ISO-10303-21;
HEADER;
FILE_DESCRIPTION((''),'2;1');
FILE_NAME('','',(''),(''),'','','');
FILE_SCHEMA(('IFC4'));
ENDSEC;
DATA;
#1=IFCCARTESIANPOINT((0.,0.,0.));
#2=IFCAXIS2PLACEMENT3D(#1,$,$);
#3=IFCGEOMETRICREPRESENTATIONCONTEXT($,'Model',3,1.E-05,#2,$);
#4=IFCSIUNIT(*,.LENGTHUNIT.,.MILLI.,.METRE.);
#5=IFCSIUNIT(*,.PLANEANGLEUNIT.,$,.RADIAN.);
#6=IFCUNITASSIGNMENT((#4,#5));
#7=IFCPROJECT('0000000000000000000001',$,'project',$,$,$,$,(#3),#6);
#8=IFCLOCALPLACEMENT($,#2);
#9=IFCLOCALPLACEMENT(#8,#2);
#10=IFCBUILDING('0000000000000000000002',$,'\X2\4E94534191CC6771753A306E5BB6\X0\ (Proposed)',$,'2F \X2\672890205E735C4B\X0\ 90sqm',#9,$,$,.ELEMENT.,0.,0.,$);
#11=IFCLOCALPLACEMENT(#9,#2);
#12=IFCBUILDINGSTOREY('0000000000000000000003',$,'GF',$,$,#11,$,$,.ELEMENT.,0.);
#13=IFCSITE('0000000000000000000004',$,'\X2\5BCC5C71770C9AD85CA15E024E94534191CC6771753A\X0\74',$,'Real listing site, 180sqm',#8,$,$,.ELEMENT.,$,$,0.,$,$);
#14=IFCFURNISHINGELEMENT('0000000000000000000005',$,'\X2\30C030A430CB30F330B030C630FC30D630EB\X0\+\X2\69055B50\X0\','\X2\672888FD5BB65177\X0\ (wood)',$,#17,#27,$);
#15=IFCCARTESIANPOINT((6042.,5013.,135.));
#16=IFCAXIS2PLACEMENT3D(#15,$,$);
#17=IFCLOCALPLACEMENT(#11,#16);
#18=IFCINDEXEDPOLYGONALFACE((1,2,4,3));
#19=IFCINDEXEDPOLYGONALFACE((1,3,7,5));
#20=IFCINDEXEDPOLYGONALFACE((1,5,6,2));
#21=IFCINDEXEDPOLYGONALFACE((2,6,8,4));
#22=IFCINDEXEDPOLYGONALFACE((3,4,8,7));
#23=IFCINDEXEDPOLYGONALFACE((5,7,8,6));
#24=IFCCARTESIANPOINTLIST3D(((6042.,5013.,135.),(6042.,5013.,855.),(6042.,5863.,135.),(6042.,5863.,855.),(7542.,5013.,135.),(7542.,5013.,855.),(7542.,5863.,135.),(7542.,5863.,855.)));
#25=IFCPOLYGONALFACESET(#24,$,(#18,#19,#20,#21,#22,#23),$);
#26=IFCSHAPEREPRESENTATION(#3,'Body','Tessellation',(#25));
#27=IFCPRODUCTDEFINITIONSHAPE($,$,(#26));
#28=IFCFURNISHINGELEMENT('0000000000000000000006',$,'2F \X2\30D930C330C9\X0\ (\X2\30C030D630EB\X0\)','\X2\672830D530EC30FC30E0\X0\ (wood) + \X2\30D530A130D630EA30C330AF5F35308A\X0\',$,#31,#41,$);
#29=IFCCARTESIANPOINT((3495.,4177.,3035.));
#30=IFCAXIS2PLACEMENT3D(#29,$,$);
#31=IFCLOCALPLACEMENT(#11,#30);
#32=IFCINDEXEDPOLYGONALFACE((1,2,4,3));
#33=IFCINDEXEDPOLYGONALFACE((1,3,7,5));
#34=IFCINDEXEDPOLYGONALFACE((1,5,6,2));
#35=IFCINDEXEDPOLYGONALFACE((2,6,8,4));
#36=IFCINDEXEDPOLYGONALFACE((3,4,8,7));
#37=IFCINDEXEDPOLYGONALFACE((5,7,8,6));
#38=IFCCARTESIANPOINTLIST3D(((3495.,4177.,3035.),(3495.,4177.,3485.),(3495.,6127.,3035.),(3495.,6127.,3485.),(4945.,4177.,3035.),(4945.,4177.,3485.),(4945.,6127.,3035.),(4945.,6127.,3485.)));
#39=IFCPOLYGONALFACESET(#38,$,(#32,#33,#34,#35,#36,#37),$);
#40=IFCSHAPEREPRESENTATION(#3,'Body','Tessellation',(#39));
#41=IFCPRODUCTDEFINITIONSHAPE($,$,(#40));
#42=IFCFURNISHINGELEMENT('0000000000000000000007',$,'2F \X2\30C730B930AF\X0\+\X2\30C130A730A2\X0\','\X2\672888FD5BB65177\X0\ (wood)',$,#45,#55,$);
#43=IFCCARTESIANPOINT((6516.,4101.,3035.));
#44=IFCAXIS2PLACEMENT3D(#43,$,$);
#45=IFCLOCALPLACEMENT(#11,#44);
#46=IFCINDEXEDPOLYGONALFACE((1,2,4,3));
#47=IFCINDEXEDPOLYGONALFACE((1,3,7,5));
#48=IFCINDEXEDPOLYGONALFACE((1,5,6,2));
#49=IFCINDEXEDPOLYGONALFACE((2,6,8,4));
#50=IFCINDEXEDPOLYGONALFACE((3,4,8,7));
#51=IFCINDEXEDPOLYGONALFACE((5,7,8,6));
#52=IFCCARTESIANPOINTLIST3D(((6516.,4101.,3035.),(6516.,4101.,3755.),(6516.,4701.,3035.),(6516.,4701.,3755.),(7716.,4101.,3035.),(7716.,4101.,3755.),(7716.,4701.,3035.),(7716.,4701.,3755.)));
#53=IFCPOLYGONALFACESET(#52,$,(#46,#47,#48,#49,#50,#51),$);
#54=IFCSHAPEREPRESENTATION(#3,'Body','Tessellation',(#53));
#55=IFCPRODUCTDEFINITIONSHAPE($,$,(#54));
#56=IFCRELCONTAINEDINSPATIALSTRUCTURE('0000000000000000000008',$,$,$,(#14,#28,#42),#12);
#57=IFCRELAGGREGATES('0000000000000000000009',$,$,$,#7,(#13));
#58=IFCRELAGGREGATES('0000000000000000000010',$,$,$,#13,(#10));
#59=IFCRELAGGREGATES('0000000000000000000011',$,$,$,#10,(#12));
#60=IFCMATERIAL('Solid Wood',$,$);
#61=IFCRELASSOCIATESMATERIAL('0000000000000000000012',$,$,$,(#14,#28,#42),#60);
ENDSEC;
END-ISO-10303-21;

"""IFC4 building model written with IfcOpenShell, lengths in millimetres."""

from ifc_helpers import new_model, si_unit, frame, frame_2d, origin, place, context, project, spatial, rectangle, extrude, material, element, save


model = new_model("IFC4")

# Units and contexts
model_context = context("Model", 3, precision=1e-05, world=origin())
ifc_project = project(units=[si_unit("LENGTHUNIT", "METRE", prefix="MILLI"), si_unit("PLANEANGLEUNIT", "RADIAN")], contexts=[model_context])

# Site, building, storey
site_placement = place(None, origin())
site = spatial("IfcSite", under=ifc_project, at=site_placement, Name="富山県高岡市五十里東町74", ObjectType="Real listing site, 180sqm", CompositionType="ELEMENT", RefElevation=0.0)
building_placement = place(site_placement, origin())
building = spatial("IfcBuilding", under=site, at=building_placement, Name="五十里東町の家 (Proposed)", ObjectType="2F 木造平屋 90sqm", CompositionType="ELEMENT", ElevationOfRefHeight=0.0, ElevationOfTerrain=0.0)
storey_placement = place(building_placement, origin())
storey = spatial("IfcBuildingStorey", under=building, at=storey_placement, Name="GF", CompositionType="ELEMENT", Elevation=0.0)

# Shared definitions
ifc_material_1 = material(Name="Solid Wood")

# Furnishing elements
furnishing_1_placement = place(storey_placement, frame((6042.0, 5013.0, 135.0)))
element("IfcFurnishingElement", 1, at=furnishing_1_placement, inside=storey, material=ifc_material_1, Name="ダイニングテーブル+椅子", Description="木製家具 (wood)", context=model_context, shape_type="SweptSolid", body=[
    extrude(rectangle(XDim=1500.0, YDim=850.0, at=frame_2d((750.0, 425.0))), frame((6042.0, 5013.0, 135.0)), (0.0, 0.0, 1.0), 720.0),
])
furnishing_2_placement = place(storey_placement, frame((3495.0, 4177.0, 3035.0)))
element("IfcFurnishingElement", 2, at=furnishing_2_placement, inside=storey, material=ifc_material_1, Name="2F ベッド (ダブル)", Description="木フレーム (wood) + ファブリック張り", context=model_context, shape_type="SweptSolid", body=[
    extrude(rectangle(XDim=1450.0, YDim=1950.0, at=frame_2d((725.0, 975.0))), frame((3495.0, 4177.0, 3035.0)), (0.0, 0.0, 1.0), 450.0),
])
furnishing_3_placement = place(storey_placement, frame((6516.0, 4101.0, 3035.0)))
element("IfcFurnishingElement", 3, at=furnishing_3_placement, inside=storey, material=ifc_material_1, Name="2F デスク+チェア", Description="木製家具 (wood)", context=model_context, shape_type="SweptSolid", body=[
    extrude(rectangle(XDim=1200.0, YDim=600.0, at=frame_2d((600.0, 300.0))), frame((6516.0, 4101.0, 3035.0)), (0.0, 0.0, 1.0), 720.0),
])

save(model, "model.ifc")
